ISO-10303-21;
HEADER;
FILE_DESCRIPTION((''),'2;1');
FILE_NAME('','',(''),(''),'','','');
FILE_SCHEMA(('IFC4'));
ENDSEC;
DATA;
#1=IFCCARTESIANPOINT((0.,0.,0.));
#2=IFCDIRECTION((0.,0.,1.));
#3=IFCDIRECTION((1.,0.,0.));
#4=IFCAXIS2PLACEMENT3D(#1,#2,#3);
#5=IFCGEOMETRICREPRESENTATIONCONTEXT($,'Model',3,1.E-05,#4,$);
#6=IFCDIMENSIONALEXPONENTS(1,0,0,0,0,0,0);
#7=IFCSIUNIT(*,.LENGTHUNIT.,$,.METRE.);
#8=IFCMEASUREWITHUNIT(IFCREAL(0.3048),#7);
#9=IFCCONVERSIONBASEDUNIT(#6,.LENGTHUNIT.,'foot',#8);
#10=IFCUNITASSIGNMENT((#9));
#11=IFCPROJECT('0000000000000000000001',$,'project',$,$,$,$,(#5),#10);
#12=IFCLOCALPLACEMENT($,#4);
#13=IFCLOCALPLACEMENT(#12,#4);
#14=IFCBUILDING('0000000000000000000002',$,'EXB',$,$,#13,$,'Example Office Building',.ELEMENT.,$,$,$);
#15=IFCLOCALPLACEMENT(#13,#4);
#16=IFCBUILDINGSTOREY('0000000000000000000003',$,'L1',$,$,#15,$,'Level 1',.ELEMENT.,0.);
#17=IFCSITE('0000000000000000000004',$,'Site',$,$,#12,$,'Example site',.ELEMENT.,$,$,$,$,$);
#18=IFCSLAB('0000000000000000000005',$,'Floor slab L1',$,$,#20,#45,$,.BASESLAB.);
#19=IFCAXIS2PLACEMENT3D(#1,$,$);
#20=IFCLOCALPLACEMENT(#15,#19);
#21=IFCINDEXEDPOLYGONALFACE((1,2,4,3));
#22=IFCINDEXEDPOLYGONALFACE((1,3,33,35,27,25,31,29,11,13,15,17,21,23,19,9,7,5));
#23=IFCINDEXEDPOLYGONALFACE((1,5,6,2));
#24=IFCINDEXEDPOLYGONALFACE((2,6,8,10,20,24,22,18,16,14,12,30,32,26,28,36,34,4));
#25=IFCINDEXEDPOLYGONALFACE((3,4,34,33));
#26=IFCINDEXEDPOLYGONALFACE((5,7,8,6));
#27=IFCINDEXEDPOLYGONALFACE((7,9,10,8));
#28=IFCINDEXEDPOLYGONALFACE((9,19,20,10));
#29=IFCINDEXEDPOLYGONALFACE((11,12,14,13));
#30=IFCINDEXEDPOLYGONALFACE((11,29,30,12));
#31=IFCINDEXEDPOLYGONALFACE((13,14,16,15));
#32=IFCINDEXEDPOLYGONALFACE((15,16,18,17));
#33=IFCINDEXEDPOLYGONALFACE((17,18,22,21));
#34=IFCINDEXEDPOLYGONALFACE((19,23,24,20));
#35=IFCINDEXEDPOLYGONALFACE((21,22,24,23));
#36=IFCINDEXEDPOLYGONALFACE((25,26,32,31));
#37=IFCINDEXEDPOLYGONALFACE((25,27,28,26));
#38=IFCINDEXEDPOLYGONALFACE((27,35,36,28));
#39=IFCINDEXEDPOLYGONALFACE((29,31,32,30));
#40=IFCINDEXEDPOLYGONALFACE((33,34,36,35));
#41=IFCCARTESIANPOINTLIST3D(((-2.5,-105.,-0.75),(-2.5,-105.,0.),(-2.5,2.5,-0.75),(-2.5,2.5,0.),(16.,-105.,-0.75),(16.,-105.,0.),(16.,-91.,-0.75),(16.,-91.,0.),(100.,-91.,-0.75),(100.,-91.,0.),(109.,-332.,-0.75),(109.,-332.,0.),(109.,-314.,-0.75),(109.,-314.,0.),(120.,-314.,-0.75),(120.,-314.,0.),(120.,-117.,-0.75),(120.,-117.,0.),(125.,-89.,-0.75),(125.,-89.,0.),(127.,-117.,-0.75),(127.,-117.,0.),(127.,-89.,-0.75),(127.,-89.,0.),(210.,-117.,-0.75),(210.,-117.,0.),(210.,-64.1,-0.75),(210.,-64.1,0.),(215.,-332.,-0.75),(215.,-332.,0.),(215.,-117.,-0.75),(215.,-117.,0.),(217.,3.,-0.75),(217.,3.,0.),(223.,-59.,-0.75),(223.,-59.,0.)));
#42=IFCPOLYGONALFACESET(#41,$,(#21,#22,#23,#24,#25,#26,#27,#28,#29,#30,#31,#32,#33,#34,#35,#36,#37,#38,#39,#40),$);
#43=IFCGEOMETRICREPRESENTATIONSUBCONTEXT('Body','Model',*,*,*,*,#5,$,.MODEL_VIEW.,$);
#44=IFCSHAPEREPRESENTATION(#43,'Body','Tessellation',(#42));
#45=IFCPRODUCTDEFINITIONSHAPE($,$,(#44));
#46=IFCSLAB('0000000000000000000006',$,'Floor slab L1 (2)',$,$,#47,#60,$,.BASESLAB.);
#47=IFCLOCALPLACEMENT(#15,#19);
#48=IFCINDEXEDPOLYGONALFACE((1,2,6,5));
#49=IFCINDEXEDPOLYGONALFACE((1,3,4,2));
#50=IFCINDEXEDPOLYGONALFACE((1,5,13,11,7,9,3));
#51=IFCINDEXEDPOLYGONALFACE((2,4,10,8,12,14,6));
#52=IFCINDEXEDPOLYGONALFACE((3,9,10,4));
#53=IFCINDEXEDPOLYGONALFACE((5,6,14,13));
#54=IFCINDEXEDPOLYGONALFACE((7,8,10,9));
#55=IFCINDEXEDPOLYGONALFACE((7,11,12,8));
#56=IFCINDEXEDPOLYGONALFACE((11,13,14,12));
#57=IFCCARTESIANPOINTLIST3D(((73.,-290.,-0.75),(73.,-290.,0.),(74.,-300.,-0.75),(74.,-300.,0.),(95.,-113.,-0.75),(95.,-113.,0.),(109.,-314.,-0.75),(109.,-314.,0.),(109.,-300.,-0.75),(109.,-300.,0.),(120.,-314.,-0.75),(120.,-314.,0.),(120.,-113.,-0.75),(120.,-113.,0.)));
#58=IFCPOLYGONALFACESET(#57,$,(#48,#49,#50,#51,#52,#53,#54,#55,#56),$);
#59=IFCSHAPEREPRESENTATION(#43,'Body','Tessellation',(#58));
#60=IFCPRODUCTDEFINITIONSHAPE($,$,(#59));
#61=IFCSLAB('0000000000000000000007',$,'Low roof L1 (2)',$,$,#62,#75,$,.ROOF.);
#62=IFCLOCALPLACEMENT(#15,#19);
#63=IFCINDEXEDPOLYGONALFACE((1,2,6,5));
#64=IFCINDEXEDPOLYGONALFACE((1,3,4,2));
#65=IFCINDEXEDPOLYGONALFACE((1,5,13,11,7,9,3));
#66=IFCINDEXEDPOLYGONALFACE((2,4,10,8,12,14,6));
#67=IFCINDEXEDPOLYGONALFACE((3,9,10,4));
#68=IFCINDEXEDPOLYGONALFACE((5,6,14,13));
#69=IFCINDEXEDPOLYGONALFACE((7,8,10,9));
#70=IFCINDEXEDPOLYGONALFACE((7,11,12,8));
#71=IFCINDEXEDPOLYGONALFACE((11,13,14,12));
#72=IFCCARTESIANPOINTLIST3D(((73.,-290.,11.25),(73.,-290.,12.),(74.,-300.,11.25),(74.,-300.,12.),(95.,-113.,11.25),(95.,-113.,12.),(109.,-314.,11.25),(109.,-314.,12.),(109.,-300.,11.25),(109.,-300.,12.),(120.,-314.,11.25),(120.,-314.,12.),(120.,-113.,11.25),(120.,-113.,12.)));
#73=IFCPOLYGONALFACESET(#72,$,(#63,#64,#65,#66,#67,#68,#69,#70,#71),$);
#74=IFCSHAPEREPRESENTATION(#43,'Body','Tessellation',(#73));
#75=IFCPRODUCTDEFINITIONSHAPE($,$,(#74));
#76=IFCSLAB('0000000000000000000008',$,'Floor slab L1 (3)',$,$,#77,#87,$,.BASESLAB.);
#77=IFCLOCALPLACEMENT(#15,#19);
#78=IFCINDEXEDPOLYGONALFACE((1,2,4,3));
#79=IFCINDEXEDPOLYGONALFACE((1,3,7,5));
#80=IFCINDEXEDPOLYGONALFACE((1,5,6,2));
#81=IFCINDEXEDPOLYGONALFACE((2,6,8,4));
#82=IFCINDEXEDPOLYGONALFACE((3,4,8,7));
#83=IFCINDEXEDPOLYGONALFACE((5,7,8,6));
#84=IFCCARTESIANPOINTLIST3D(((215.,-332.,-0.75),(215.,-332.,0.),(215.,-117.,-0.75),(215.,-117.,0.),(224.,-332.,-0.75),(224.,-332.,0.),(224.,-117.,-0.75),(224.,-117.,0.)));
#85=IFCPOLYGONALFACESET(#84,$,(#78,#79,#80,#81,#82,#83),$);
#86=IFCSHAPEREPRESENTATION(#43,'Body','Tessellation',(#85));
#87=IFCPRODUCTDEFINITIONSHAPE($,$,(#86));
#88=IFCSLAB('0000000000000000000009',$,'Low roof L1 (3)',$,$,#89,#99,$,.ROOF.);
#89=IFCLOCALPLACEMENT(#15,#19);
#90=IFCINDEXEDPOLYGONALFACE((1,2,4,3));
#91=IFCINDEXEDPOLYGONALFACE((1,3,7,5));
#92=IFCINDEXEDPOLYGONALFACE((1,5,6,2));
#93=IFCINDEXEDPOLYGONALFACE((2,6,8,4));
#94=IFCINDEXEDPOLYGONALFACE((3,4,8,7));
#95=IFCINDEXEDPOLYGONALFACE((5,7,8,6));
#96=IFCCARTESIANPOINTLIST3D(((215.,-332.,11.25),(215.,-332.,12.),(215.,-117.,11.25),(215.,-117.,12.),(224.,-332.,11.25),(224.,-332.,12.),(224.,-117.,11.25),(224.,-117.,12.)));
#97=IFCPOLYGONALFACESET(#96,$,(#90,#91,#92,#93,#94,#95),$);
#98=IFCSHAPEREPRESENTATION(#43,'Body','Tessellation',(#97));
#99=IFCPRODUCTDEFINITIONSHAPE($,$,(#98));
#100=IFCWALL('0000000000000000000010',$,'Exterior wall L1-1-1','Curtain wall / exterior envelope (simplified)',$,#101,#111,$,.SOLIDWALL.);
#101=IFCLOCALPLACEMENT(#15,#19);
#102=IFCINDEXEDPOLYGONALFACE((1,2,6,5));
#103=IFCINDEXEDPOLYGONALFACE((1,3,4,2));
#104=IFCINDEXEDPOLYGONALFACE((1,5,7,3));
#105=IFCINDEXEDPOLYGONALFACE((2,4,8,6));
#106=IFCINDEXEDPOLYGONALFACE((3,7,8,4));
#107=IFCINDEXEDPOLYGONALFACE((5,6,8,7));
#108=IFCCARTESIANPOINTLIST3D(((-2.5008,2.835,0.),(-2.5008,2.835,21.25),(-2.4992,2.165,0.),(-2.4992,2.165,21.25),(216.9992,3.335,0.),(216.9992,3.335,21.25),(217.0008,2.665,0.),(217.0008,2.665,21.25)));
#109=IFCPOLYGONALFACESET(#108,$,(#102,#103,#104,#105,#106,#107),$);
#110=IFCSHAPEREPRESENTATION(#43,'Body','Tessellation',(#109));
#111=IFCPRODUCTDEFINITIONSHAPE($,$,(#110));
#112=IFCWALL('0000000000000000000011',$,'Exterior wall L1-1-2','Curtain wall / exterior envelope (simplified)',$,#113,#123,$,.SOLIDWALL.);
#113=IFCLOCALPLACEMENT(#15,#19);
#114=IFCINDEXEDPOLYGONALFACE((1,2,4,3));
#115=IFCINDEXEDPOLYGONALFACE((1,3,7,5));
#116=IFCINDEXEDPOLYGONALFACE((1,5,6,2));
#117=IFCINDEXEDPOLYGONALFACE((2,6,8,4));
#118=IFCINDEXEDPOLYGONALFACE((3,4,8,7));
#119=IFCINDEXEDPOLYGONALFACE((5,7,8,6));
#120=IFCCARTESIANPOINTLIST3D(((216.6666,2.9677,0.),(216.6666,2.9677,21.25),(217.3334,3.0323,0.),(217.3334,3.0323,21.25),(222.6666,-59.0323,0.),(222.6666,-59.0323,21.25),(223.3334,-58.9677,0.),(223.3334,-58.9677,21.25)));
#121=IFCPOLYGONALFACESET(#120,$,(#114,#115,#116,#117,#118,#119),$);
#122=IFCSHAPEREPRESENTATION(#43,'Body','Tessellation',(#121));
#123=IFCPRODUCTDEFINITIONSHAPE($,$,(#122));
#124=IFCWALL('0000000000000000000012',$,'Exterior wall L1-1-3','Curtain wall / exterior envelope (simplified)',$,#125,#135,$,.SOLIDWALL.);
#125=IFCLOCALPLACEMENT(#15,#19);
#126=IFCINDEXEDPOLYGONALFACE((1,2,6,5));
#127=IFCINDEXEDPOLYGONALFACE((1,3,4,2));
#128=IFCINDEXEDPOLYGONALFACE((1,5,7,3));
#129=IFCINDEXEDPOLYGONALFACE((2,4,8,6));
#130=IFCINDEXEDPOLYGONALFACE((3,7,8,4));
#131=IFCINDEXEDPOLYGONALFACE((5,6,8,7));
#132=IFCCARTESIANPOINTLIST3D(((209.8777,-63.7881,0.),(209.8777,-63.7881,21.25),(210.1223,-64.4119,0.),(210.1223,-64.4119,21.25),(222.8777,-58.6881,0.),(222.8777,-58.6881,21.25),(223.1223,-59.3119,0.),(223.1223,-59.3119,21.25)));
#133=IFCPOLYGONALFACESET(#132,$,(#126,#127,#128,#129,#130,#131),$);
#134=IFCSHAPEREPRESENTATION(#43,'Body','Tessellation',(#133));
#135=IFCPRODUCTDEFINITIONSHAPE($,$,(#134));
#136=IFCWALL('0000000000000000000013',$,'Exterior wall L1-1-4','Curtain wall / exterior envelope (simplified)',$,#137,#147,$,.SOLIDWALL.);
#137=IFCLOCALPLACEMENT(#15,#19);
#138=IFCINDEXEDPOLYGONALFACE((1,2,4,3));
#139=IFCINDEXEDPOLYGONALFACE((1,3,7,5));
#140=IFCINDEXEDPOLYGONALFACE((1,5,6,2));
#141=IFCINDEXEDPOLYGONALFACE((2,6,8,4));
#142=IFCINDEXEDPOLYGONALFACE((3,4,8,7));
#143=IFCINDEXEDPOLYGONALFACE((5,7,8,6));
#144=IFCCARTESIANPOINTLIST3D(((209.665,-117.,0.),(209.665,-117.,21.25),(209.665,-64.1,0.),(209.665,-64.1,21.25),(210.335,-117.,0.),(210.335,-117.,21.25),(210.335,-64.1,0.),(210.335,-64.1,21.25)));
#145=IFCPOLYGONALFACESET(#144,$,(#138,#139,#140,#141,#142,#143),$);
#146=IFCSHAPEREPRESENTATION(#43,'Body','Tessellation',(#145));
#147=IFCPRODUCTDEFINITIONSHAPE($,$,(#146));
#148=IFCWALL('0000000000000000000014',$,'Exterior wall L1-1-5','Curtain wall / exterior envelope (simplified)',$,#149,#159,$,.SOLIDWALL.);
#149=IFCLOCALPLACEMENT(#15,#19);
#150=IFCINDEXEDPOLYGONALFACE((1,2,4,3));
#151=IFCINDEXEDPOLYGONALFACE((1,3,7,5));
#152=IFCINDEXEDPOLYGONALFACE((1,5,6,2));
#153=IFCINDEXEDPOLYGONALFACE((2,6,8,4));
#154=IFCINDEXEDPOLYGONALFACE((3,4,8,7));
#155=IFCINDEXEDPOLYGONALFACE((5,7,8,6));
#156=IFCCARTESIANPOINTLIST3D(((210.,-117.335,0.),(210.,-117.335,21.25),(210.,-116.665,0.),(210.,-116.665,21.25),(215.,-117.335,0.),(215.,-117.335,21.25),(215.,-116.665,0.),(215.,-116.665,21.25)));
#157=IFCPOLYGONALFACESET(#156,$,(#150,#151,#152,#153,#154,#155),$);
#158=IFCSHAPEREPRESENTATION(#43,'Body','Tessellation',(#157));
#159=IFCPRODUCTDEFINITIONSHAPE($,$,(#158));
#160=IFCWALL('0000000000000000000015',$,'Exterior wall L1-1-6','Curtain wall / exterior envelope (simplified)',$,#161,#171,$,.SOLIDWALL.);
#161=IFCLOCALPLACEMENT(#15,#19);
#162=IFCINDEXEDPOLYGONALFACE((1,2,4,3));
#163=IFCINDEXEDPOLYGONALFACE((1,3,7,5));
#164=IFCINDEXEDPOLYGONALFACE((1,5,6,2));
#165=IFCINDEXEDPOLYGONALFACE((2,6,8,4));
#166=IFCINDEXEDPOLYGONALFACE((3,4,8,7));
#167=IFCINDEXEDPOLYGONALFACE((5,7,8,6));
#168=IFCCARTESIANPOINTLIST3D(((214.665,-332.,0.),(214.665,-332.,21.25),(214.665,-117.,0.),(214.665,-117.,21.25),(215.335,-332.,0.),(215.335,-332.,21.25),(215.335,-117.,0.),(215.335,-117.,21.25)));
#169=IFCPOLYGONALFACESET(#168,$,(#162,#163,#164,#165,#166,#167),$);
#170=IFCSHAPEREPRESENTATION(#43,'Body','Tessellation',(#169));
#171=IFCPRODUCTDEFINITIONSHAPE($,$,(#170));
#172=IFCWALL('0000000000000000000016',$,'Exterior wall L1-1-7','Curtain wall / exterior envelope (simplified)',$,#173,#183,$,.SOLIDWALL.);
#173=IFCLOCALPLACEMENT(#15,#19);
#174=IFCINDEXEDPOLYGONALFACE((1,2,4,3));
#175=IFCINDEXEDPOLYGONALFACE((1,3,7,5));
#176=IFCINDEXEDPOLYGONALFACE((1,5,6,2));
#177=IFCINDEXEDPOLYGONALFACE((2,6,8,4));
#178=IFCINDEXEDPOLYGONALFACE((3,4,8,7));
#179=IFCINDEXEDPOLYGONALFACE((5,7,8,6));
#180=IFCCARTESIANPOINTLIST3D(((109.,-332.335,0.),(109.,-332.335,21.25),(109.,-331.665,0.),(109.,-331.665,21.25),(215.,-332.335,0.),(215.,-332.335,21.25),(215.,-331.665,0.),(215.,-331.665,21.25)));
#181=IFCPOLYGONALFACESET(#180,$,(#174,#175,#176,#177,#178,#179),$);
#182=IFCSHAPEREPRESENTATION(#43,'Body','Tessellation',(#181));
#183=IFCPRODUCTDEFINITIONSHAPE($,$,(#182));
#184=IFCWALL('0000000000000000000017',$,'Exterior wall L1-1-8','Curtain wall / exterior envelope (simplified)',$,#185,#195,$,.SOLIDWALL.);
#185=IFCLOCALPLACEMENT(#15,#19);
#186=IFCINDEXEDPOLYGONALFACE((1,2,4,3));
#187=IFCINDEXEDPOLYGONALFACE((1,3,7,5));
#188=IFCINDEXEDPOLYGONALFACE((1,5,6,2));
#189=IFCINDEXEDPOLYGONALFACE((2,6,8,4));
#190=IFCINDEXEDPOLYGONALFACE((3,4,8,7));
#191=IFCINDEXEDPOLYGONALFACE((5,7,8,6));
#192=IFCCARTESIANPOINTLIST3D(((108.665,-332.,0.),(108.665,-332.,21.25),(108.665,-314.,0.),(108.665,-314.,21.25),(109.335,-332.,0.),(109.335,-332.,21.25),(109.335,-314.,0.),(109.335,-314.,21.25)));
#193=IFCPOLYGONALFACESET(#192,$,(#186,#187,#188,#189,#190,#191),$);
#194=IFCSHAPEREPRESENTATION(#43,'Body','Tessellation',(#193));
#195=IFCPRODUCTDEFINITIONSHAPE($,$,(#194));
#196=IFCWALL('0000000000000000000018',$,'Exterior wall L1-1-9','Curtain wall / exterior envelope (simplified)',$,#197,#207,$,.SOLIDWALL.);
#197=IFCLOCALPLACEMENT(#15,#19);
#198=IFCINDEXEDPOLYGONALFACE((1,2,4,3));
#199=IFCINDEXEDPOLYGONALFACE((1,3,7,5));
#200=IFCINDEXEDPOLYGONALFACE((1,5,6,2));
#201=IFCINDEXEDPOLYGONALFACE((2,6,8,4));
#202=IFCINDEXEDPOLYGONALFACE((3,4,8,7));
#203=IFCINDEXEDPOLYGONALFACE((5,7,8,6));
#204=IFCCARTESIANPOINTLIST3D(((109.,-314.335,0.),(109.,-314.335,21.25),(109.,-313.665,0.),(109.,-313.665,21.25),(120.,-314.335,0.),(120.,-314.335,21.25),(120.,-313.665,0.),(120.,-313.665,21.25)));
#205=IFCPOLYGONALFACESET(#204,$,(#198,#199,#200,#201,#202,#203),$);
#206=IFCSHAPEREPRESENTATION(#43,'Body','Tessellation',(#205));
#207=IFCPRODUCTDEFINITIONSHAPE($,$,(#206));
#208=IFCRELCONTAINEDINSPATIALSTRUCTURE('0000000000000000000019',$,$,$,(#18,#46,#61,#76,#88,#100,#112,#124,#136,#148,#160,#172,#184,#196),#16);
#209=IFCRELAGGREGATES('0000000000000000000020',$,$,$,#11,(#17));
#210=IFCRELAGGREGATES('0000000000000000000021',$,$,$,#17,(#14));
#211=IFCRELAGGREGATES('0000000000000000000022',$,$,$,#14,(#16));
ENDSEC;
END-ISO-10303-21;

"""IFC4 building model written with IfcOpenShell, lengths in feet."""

from ifc_helpers import new_model, entity, si_unit, converted_unit, frame, frame_2d, origin, origin_with_axes, place, context, subcontext, project, spatial, polyline, rectangle, outline, extrude, element, save


model = new_model("IFC4")

# Units and contexts
model_context = context("Model", 3, precision=1e-05, world=origin_with_axes())
body_context = subcontext(model_context, "Body", "Model", "MODEL_VIEW")
ifc_project = project(units=[converted_unit("LENGTHUNIT", "foot", entity("IfcReal", 0.3048), si_unit("LENGTHUNIT", "METRE"), dimensions=[1, 0, 0, 0, 0, 0, 0])], contexts=[model_context])

# Site, building, storey
site_placement = place(None, origin_with_axes())
site = spatial("IfcSite", under=ifc_project, at=site_placement, Name="Site", LongName="Example site", CompositionType="ELEMENT")
building_placement = place(site_placement, origin_with_axes())
building = spatial("IfcBuilding", under=site, at=building_placement, Name="EXB", LongName="Example Office Building", CompositionType="ELEMENT")
storey_placement = place(building_placement, origin_with_axes())
storey = spatial("IfcBuildingStorey", under=building, at=storey_placement, Name="L1", LongName="Level 1", CompositionType="ELEMENT", Elevation=0.0)

# Slabs
slab_1_placement = place(storey_placement, origin_with_axes())
element("IfcSlab", 1, at=slab_1_placement, inside=storey, Name="Floor slab L1", PredefinedType="BASESLAB", context=body_context, shape_type="SweptSolid", body=[
    extrude(outline(polyline([(-2.5, 2.5), (217.0, 3.0), (223.0, -59.0), (210.0, -64.1), (210.0, -117.0), (215.0, -117.0), (215.0, -332.0), (109.0, -332.0), (109.0, -314.0), (120.0, -314.0), (120.0, -117.0), (127.0, -117.0), (127.0, -89.0), (125.0, -89.0), (100.0, -91.0), (16.0, -91.0), (16.0, -105.0), (-2.5, -105.0), (-2.5, 2.5)])), frame((0.0, 0.0, -0.75)), (0.0, 0.0, 1.0), 0.75),
])
slab_2_placement = place(storey_placement, origin_with_axes())
element("IfcSlab", 2, at=slab_2_placement, inside=storey, Name="Floor slab L1 (2)", PredefinedType="BASESLAB", context=body_context, shape_type="SweptSolid", body=[
    extrude(outline(polyline([(95.0, -113.0), (120.0, -113.0), (120.0, -314.0), (109.0, -314.0), (109.0, -300.0), (74.0, -300.0), (73.0, -290.0), (95.0, -113.0)])), frame((0.0, 0.0, -0.75)), (0.0, 0.0, 1.0), 0.75),
])
slab_3_placement = place(storey_placement, origin_with_axes())
element("IfcSlab", 3, at=slab_3_placement, inside=storey, Name="Low roof L1 (2)", PredefinedType="ROOF", context=body_context, shape_type="SweptSolid", body=[
    extrude(outline(polyline([(95.0, -113.0), (120.0, -113.0), (120.0, -314.0), (109.0, -314.0), (109.0, -300.0), (74.0, -300.0), (73.0, -290.0), (95.0, -113.0)])), frame((0.0, 0.0, 11.25)), (0.0, 0.0, 1.0), 0.75),
])
slab_4_placement = place(storey_placement, origin_with_axes())
element("IfcSlab", 4, at=slab_4_placement, inside=storey, Name="Floor slab L1 (3)", PredefinedType="BASESLAB", context=body_context, shape_type="SweptSolid", body=[
    extrude(outline(polyline([(215.0, -117.0), (224.0, -117.0), (224.0, -332.0), (215.0, -332.0), (215.0, -117.0)])), frame((0.0, 0.0, -0.75)), (0.0, 0.0, 1.0), 0.75),
])
slab_5_placement = place(storey_placement, origin_with_axes())
element("IfcSlab", 5, at=slab_5_placement, inside=storey, Name="Low roof L1 (3)", PredefinedType="ROOF", context=body_context, shape_type="SweptSolid", body=[
    extrude(outline(polyline([(215.0, -117.0), (224.0, -117.0), (224.0, -332.0), (215.0, -332.0), (215.0, -117.0)])), frame((0.0, 0.0, 11.25)), (0.0, 0.0, 1.0), 0.75),
])

# Walls
wall_1_placement = place(storey_placement, frame((-2.5, 2.5, 0.0), z_axis=(0.0, 0.0, 1.0), x_axis=(0.999997, 0.002278, 0.0)))
element("IfcWall", 6, at=wall_1_placement, inside=storey, Name="Exterior wall L1-1-1", Description="Curtain wall / exterior envelope (simplified)", PredefinedType="SOLIDWALL", context=body_context, shape_type="SweptSolid", body=[
    extrude(rectangle(XDim=219.5006, YDim=0.67, at=frame_2d((109.7503, 0.0))), origin(), (0.0, 0.0, 1.0), 21.25),
])
wall_2_placement = place(storey_placement, frame((217.0, 3.0, 0.0), z_axis=(0.0, 0.0, 1.0), x_axis=(0.096324, -0.99535, 0.0)))
element("IfcWall", 7, at=wall_2_placement, inside=storey, Name="Exterior wall L1-1-2", Description="Curtain wall / exterior envelope (simplified)", PredefinedType="SOLIDWALL", context=body_context, shape_type="SweptSolid", body=[
    extrude(rectangle(XDim=62.2896, YDim=0.67, at=frame_2d((31.1448, 0.0))), origin(), (0.0, 0.0, 1.0), 21.25),
])
wall_3_placement = place(storey_placement, frame((223.0, -59.0, 0.0), z_axis=(0.0, 0.0, 1.0), x_axis=(-0.930925, -0.365209, 0.0)))
element("IfcWall", 8, at=wall_3_placement, inside=storey, Name="Exterior wall L1-1-3", Description="Curtain wall / exterior envelope (simplified)", PredefinedType="SOLIDWALL", context=body_context, shape_type="SweptSolid", body=[
    extrude(rectangle(XDim=13.9646, YDim=0.67, at=frame_2d((6.9823, 0.0))), origin(), (0.0, 0.0, 1.0), 21.25),
])
wall_4_placement = place(storey_placement, frame((210.0, -64.1, 0.0), z_axis=(0.0, 0.0, 1.0), x_axis=(0.0, -1.0, 0.0)))
element("IfcWall", 9, at=wall_4_placement, inside=storey, Name="Exterior wall L1-1-4", Description="Curtain wall / exterior envelope (simplified)", PredefinedType="SOLIDWALL", context=body_context, shape_type="SweptSolid", body=[
    extrude(rectangle(XDim=52.9, YDim=0.67, at=frame_2d((26.45, 0.0))), origin(), (0.0, 0.0, 1.0), 21.25),
])
wall_5_placement = place(storey_placement, frame((210.0, -117.0, 0.0), z_axis=(0.0, 0.0, 1.0), x_axis=(1.0, 0.0, 0.0)))
element("IfcWall", 10, at=wall_5_placement, inside=storey, Name="Exterior wall L1-1-5", Description="Curtain wall / exterior envelope (simplified)", PredefinedType="SOLIDWALL", context=body_context, shape_type="SweptSolid", body=[
    extrude(rectangle(XDim=5.0, YDim=0.67, at=frame_2d((2.5, 0.0))), origin(), (0.0, 0.0, 1.0), 21.25),
])
wall_6_placement = place(storey_placement, frame((215.0, -117.0, 0.0), z_axis=(0.0, 0.0, 1.0), x_axis=(0.0, -1.0, 0.0)))
element("IfcWall", 11, at=wall_6_placement, inside=storey, Name="Exterior wall L1-1-6", Description="Curtain wall / exterior envelope (simplified)", PredefinedType="SOLIDWALL", context=body_context, shape_type="SweptSolid", body=[
    extrude(rectangle(XDim=215.0, YDim=0.67, at=frame_2d((107.5, 0.0))), origin(), (0.0, 0.0, 1.0), 21.25),
])
wall_7_placement = place(storey_placement, frame((215.0, -332.0, 0.0), z_axis=(0.0, 0.0, 1.0), x_axis=(-1.0, 0.0, 0.0)))
element("IfcWall", 12, at=wall_7_placement, inside=storey, Name="Exterior wall L1-1-7", Description="Curtain wall / exterior envelope (simplified)", PredefinedType="SOLIDWALL", context=body_context, shape_type="SweptSolid", body=[
    extrude(rectangle(XDim=106.0, YDim=0.67, at=frame_2d((53.0, 0.0))), origin(), (0.0, 0.0, 1.0), 21.25),
])
wall_8_placement = place(storey_placement, frame((109.0, -332.0, 0.0), z_axis=(0.0, 0.0, 1.0), x_axis=(0.0, 1.0, 0.0)))
element("IfcWall", 13, at=wall_8_placement, inside=storey, Name="Exterior wall L1-1-8", Description="Curtain wall / exterior envelope (simplified)", PredefinedType="SOLIDWALL", context=body_context, shape_type="SweptSolid", body=[
    extrude(rectangle(XDim=18.0, YDim=0.67, at=frame_2d((9.0, 0.0))), origin(), (0.0, 0.0, 1.0), 21.25),
])
wall_9_placement = place(storey_placement, frame((109.0, -314.0, 0.0), z_axis=(0.0, 0.0, 1.0), x_axis=(1.0, 0.0, 0.0)))
element("IfcWall", 14, at=wall_9_placement, inside=storey, Name="Exterior wall L1-1-9", Description="Curtain wall / exterior envelope (simplified)", PredefinedType="SOLIDWALL", context=body_context, shape_type="SweptSolid", body=[
    extrude(rectangle(XDim=11.0, YDim=0.67, at=frame_2d((5.5, 0.0))), origin(), (0.0, 0.0, 1.0), 21.25),
])

save(model, "model.ifc")
